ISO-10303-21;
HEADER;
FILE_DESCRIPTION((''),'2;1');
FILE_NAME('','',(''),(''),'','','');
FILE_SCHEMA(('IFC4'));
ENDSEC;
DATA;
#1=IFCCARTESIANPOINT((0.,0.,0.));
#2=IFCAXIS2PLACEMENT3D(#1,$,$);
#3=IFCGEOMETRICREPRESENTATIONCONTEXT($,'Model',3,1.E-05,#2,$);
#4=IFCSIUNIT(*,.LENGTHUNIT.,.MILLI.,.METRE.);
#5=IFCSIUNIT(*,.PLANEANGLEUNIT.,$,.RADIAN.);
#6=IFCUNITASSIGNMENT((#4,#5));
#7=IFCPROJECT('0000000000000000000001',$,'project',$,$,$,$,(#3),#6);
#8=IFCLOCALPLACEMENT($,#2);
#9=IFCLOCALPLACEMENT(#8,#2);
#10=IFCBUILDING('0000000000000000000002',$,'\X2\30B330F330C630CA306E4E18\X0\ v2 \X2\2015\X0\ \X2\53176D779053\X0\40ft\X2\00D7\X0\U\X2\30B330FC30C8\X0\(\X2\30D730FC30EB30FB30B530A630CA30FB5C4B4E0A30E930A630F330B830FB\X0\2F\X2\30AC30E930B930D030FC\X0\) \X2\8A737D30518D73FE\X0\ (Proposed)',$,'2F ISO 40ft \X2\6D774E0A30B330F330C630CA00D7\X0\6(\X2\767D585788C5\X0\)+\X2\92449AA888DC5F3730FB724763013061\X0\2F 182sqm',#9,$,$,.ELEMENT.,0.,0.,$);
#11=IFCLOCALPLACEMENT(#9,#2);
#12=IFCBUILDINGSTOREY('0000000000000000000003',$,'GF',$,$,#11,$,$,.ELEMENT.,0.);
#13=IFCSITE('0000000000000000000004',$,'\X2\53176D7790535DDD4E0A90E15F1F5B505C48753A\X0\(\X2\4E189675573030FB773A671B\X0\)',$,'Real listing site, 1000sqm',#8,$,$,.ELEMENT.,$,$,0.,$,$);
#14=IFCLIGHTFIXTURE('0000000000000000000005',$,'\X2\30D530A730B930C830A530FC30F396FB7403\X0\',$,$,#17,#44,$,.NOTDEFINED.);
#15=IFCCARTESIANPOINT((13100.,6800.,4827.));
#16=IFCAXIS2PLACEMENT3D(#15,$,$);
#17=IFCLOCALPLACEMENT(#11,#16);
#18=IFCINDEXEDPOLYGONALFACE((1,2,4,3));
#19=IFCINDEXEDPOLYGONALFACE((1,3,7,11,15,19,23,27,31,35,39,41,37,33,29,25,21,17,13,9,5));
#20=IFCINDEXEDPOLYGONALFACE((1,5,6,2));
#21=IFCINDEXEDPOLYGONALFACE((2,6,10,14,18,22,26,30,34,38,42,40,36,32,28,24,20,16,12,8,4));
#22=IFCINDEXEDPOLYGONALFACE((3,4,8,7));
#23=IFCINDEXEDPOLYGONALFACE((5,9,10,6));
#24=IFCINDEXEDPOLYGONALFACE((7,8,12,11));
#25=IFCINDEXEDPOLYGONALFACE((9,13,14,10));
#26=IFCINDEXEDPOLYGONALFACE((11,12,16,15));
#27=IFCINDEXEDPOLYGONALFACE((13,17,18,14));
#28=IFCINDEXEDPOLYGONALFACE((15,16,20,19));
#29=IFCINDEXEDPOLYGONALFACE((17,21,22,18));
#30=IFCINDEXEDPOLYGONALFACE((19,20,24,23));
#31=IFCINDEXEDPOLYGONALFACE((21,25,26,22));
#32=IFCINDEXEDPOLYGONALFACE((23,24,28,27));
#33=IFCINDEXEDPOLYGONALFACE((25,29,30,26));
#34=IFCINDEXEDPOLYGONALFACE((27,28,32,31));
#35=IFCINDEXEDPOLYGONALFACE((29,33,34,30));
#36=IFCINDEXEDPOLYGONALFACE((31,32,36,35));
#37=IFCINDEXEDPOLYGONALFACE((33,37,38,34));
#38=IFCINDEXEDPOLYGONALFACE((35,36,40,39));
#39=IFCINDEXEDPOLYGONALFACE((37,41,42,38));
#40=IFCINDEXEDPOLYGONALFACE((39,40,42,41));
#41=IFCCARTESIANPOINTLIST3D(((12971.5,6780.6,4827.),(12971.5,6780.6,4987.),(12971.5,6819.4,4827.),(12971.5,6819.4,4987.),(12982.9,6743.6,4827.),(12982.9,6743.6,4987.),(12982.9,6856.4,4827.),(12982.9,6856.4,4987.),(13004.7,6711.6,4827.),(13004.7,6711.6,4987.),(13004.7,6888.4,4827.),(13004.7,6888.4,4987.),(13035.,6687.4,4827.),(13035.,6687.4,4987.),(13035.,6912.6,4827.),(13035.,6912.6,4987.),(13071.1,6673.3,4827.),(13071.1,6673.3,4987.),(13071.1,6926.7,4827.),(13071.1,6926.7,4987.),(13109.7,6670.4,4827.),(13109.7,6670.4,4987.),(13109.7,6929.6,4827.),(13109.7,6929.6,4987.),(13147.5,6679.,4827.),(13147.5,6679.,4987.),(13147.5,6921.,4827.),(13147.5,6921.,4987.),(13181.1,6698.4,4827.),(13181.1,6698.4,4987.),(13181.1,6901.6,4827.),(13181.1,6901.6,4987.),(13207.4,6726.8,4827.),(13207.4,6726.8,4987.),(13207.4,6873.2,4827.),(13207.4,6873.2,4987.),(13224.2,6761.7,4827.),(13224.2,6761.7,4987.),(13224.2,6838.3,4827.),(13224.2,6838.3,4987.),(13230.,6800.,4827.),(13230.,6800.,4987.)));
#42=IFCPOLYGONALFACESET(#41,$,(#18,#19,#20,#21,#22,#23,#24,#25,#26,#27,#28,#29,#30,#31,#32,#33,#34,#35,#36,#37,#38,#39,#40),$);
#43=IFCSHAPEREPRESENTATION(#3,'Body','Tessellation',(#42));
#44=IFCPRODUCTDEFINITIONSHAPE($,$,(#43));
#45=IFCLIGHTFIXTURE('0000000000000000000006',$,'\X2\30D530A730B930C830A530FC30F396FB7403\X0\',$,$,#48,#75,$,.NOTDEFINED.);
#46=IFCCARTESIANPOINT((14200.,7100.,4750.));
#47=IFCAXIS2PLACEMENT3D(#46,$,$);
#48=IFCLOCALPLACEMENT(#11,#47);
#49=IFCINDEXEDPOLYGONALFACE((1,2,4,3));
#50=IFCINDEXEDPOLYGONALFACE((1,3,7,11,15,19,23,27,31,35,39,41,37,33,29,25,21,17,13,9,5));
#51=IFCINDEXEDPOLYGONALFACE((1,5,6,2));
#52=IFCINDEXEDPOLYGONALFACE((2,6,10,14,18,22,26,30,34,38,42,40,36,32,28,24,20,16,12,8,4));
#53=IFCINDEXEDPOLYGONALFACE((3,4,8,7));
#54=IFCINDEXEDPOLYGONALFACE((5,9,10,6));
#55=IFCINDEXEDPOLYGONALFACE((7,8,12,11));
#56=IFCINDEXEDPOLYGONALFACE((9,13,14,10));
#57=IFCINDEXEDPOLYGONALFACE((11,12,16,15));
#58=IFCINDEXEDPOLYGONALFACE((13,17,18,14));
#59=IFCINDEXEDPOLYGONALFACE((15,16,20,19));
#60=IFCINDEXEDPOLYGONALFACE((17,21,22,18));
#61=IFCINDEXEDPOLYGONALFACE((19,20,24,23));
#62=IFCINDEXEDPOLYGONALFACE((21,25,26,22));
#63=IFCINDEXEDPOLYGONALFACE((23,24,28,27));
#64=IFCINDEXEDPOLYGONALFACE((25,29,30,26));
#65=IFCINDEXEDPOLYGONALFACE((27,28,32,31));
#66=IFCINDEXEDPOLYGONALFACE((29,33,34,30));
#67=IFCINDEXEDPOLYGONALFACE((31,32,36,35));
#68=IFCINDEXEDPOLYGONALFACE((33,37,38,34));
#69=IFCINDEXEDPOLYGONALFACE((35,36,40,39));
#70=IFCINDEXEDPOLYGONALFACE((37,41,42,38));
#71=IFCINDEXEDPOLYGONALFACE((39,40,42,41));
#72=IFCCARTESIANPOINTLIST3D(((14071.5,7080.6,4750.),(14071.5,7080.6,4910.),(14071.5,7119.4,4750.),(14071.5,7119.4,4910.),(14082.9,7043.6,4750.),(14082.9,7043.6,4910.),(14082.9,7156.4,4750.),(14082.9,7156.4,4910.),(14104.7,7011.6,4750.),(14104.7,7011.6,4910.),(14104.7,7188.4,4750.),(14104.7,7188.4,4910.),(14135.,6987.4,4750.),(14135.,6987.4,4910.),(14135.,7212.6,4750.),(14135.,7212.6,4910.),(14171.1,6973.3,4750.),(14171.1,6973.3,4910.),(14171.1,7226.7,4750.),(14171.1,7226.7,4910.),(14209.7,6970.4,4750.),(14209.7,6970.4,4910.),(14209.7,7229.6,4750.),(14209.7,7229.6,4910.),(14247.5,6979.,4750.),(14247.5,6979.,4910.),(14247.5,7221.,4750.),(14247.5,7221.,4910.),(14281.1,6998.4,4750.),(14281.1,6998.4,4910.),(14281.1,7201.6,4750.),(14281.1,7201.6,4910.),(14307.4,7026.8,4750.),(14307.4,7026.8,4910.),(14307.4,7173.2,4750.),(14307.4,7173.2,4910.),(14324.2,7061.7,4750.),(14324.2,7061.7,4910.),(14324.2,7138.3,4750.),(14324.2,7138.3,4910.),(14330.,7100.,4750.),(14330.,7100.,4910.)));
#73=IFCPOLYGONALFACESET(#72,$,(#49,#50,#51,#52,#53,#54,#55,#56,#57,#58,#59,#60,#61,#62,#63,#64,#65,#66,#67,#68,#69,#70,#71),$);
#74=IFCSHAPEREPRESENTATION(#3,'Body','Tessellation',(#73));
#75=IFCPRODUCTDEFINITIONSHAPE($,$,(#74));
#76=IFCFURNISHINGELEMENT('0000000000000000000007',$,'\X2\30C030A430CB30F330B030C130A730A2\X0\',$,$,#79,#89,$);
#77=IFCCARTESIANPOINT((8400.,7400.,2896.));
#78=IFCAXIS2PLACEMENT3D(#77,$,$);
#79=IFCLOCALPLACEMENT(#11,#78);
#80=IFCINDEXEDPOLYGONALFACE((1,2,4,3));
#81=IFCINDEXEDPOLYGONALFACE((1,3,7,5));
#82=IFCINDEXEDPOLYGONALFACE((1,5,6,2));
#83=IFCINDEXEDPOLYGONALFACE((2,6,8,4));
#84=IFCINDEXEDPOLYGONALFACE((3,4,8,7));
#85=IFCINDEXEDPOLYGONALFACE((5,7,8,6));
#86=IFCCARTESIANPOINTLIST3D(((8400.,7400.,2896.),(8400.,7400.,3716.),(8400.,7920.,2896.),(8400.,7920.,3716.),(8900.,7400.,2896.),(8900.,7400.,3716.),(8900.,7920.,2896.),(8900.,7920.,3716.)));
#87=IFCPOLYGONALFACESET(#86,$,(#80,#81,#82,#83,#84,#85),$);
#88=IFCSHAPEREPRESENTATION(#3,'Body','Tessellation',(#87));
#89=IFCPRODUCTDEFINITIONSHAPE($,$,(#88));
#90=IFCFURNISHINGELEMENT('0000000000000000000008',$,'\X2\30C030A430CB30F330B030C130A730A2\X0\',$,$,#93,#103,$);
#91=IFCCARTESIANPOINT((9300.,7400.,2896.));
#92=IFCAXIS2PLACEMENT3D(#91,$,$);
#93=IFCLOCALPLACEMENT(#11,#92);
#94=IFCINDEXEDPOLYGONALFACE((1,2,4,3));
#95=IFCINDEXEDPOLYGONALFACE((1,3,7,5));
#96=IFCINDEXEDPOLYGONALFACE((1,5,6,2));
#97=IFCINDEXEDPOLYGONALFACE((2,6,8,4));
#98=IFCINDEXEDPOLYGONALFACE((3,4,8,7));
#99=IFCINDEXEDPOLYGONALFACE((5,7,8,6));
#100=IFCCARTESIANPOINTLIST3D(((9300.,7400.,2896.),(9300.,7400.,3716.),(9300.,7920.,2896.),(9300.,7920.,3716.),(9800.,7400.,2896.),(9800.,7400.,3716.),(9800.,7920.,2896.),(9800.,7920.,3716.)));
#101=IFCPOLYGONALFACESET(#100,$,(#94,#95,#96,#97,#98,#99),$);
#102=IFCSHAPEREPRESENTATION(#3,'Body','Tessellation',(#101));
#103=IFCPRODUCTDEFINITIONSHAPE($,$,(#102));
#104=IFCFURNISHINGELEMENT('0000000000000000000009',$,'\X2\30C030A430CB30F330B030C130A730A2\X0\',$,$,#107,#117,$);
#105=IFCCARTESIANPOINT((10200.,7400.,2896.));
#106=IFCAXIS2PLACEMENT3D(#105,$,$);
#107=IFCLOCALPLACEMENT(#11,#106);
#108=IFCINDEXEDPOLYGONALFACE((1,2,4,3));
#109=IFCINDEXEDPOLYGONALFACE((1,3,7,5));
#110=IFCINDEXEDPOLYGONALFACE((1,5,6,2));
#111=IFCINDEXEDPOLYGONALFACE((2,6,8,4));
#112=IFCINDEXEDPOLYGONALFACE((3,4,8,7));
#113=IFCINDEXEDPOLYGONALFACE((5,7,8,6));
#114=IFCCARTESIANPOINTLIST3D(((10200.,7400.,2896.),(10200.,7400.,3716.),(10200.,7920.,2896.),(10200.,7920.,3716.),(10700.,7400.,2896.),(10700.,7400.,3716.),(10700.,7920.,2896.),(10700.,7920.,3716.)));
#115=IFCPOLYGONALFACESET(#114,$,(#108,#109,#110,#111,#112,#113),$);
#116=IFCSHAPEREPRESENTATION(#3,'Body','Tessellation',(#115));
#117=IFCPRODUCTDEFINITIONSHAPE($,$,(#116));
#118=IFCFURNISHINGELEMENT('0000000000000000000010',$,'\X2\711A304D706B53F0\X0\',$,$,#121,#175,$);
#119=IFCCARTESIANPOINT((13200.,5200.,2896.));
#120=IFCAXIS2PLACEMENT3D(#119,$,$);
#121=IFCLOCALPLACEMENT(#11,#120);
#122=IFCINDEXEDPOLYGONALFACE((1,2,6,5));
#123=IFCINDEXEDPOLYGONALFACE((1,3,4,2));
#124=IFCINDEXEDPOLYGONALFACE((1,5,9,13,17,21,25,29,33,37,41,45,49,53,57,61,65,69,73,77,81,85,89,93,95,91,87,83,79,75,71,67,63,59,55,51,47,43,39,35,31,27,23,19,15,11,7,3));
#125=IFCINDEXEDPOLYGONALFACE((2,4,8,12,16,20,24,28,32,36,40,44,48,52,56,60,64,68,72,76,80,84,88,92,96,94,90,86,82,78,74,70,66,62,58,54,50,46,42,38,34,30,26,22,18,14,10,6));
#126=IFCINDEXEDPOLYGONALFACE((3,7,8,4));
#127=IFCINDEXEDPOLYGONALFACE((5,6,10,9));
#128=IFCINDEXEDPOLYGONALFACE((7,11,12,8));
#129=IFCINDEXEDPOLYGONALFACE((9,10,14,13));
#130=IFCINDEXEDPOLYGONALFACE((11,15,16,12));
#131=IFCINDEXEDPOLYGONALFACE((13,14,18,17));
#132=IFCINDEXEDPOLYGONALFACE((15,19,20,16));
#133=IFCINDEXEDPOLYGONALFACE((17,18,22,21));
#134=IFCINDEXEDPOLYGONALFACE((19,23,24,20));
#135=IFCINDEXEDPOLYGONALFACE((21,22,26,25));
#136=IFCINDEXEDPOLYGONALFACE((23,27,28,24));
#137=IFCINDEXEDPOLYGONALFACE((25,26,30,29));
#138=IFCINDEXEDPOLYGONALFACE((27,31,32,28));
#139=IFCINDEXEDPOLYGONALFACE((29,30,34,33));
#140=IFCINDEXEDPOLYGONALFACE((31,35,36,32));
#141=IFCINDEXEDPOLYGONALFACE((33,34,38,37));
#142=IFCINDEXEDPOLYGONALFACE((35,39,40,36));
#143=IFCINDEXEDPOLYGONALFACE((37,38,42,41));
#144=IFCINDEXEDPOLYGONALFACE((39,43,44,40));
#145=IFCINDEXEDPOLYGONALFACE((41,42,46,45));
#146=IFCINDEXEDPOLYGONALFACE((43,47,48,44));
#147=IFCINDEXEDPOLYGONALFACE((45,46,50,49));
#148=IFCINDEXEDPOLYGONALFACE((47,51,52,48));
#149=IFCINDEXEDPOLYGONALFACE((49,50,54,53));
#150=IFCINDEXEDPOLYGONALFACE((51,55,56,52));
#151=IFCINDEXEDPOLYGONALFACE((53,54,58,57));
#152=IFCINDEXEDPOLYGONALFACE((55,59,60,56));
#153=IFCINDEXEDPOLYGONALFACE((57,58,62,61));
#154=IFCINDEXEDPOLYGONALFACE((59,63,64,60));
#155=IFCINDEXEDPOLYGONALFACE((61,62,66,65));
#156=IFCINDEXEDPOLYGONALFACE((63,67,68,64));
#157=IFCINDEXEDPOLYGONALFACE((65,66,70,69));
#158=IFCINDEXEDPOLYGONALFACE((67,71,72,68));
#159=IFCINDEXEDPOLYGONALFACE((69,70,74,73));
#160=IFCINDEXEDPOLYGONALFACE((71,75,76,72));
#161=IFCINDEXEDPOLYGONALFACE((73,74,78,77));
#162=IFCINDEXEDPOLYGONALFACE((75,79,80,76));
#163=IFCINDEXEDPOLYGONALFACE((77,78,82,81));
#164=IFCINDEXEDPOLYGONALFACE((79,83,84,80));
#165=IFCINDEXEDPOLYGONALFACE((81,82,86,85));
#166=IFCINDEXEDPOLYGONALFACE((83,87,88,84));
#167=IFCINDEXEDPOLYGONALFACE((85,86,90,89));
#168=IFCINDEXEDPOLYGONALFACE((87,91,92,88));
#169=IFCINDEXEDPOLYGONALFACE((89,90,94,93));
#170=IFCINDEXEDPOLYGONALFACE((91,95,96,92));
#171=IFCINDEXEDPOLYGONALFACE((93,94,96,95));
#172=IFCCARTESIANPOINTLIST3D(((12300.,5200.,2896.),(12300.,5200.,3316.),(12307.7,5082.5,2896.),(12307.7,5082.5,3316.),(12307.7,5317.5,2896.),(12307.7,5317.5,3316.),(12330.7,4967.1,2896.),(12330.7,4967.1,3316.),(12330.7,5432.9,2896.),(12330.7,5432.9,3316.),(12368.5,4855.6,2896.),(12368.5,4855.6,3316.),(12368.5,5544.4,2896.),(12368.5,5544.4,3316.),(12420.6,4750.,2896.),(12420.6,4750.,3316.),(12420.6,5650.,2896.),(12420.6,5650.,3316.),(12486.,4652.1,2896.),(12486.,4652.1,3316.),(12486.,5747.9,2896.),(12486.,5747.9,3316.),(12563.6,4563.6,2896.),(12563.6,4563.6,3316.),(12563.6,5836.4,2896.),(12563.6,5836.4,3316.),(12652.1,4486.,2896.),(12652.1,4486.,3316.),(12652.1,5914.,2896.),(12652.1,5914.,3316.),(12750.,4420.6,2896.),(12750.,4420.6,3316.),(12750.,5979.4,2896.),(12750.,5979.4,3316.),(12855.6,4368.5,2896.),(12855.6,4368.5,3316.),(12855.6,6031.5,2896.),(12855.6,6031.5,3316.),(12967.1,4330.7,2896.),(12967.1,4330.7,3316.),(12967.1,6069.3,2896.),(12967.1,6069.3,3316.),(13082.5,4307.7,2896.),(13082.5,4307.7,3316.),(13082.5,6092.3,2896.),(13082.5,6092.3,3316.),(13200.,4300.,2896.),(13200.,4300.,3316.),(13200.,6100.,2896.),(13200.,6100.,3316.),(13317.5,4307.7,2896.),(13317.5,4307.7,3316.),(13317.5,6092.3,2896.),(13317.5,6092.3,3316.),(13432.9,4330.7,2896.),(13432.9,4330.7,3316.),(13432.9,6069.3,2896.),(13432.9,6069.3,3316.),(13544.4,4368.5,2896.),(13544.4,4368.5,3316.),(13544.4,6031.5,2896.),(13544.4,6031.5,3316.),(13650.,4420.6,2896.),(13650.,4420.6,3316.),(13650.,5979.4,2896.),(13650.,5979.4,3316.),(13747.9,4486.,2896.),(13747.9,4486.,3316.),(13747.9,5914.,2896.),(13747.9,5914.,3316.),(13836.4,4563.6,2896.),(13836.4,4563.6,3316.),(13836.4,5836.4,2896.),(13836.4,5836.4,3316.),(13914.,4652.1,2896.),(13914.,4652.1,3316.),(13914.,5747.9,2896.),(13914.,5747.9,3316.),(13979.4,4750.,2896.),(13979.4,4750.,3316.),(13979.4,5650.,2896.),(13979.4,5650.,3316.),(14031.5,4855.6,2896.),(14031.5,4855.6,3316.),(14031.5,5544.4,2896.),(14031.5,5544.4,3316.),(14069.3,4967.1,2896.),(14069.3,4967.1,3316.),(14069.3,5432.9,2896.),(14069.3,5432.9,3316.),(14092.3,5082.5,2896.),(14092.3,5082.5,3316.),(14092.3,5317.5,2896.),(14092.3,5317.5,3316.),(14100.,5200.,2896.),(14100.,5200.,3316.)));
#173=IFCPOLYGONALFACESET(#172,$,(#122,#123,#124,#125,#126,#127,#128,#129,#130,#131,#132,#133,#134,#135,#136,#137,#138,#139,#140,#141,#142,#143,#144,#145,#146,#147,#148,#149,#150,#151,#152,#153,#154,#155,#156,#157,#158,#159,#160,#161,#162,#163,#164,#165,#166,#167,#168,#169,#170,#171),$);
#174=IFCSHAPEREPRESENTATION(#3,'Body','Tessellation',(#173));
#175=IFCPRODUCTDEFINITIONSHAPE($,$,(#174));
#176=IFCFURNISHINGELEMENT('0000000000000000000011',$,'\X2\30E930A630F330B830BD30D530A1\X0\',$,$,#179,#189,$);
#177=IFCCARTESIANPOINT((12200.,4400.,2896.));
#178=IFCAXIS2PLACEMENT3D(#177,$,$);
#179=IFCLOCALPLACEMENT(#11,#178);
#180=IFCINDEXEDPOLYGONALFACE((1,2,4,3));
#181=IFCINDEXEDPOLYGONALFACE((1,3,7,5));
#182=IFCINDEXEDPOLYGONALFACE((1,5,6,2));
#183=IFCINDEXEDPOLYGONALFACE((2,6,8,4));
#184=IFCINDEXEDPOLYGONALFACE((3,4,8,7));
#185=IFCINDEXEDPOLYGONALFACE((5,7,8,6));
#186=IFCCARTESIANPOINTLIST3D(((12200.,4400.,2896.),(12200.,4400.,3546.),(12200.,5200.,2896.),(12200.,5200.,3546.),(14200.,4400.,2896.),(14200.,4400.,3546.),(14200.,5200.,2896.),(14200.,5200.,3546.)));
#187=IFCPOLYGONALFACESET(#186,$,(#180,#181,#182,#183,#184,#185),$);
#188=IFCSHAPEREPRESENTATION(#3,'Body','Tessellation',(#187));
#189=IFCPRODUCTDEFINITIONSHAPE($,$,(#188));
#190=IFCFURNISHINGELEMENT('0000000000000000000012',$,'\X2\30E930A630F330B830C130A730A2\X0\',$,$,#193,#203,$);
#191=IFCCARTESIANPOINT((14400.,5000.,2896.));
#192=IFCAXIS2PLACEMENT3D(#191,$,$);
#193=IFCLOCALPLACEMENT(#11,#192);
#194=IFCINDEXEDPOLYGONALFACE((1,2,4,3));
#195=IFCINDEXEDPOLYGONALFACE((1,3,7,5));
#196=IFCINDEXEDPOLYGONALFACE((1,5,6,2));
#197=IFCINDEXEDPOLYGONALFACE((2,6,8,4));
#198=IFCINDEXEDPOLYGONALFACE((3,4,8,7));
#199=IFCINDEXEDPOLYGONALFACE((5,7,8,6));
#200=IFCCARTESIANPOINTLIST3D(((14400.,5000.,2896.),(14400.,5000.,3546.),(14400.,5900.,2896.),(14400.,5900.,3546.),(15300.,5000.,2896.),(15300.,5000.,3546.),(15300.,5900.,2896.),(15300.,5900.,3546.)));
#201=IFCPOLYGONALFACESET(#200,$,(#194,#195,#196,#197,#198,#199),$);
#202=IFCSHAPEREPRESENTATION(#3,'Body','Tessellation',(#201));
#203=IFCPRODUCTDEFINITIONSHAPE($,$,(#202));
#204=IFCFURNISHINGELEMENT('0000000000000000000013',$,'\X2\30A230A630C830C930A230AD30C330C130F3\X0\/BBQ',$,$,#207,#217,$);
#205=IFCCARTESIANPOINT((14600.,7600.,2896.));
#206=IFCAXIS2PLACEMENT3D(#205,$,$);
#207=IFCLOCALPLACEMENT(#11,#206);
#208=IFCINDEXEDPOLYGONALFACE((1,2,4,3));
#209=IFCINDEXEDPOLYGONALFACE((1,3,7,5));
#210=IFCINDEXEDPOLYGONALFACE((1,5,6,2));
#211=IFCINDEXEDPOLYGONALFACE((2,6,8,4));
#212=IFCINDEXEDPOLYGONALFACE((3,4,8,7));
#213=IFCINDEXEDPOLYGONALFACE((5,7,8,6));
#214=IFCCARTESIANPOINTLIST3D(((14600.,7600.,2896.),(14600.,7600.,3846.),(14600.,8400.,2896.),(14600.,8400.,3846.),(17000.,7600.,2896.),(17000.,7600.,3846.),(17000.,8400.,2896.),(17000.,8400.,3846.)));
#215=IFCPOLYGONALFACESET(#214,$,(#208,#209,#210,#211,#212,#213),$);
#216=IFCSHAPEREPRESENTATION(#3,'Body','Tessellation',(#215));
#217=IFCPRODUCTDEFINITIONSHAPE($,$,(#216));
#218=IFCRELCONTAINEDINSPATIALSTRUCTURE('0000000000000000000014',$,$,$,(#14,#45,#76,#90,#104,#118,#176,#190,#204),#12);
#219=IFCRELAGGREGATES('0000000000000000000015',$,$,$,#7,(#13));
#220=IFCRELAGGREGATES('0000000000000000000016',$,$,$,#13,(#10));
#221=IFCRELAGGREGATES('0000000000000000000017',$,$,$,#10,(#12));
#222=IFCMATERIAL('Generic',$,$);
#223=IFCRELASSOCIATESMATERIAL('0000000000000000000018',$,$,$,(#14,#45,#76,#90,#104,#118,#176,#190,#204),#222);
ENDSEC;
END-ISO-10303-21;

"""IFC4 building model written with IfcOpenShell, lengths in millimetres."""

from ifc_helpers import new_model, si_unit, frame, frame_2d, origin, origin_2d, place, context, project, spatial, rectangle, circle, extrude, material, element, save


model = new_model("IFC4")

# Units and contexts
model_context = context("Model", 3, precision=1e-05, world=origin())
ifc_project = project(units=[si_unit("LENGTHUNIT", "METRE", prefix="MILLI"), si_unit("PLANEANGLEUNIT", "RADIAN")], contexts=[model_context])

# Site, building, storey
site_placement = place(None, origin())
site = spatial("IfcSite", under=ifc_project, at=site_placement, Name="北海道川上郡弟子屈町(丘陵地・眺望)", ObjectType="Real listing site, 1000sqm", CompositionType="ELEMENT", RefElevation=0.0)
building_placement = place(site_placement, origin())
building = spatial("IfcBuilding", under=site, at=building_placement, Name="コンテナの丘 v2 ― 北海道40ft×Uコート(プール・サウナ・屋上ラウンジ・2Fガラスバー) 詳細再現 (Proposed)", ObjectType="2F ISO 40ft 海上コンテナ×6(白塗装)+鉄骨補強・片持ち2F 182sqm", CompositionType="ELEMENT", ElevationOfRefHeight=0.0, ElevationOfTerrain=0.0)
storey_placement = place(building_placement, origin())
storey = spatial("IfcBuildingStorey", under=building, at=storey_placement, Name="GF", CompositionType="ELEMENT", Elevation=0.0)

# Shared definitions
ifc_material = material(Name="Generic")

# Light fixtures
light_fixture_1_placement = place(storey_placement, frame((13100.0, 6800.0, 4827.0)))
element("IfcLightFixture", 1, at=light_fixture_1_placement, inside=storey, material=ifc_material, Name="フェストゥーン電球", PredefinedType="NOTDEFINED", context=model_context, shape_type="SweptSolid", body=[
    extrude(circle(Radius=130.0, at=origin_2d()), frame((13100.0, 6800.0, 4827.0)), (0.0, 0.0, 1.0), 160.0),
])
light_fixture_2_placement = place(storey_placement, frame((14200.0, 7100.0, 4750.0)))
element("IfcLightFixture", 2, at=light_fixture_2_placement, inside=storey, material=ifc_material, Name="フェストゥーン電球", PredefinedType="NOTDEFINED", context=model_context, shape_type="SweptSolid", body=[
    extrude(circle(Radius=130.0, at=origin_2d()), frame((14200.0, 7100.0, 4750.0)), (0.0, 0.0, 1.0), 160.0),
])

# Furnishing elements
furnishing_1_placement = place(storey_placement, frame((8400.0, 7400.0, 2896.0)))
element("IfcFurnishingElement", 3, at=furnishing_1_placement, inside=storey, material=ifc_material, Name="ダイニングチェア", context=model_context, shape_type="SweptSolid", body=[
    extrude(rectangle(XDim=500.0, YDim=520.0, at=frame_2d((250.0, 260.0))), frame((8400.0, 7400.0, 2896.0)), (0.0, 0.0, 1.0), 820.0),
])
furnishing_2_placement = place(storey_placement, frame((9300.0, 7400.0, 2896.0)))
element("IfcFurnishingElement", 4, at=furnishing_2_placement, inside=storey, material=ifc_material, Name="ダイニングチェア", context=model_context, shape_type="SweptSolid", body=[
    extrude(rectangle(XDim=500.0, YDim=520.0, at=frame_2d((250.0, 260.0))), frame((9300.0, 7400.0, 2896.0)), (0.0, 0.0, 1.0), 820.0),
])
furnishing_3_placement = place(storey_placement, frame((10200.0, 7400.0, 2896.0)))
element("IfcFurnishingElement", 5, at=furnishing_3_placement, inside=storey, material=ifc_material, Name="ダイニングチェア", context=model_context, shape_type="SweptSolid", body=[
    extrude(rectangle(XDim=500.0, YDim=520.0, at=frame_2d((250.0, 260.0))), frame((10200.0, 7400.0, 2896.0)), (0.0, 0.0, 1.0), 820.0),
])
furnishing_4_placement = place(storey_placement, frame((13200.0, 5200.0, 2896.0)))
element("IfcFurnishingElement", 6, at=furnishing_4_placement, inside=storey, material=ifc_material, Name="焚き火台", context=model_context, shape_type="SweptSolid", body=[
    extrude(circle(Radius=900.0, at=origin_2d()), frame((13200.0, 5200.0, 2896.0)), (0.0, 0.0, 1.0), 420.0),
])
furnishing_5_placement = place(storey_placement, frame((12200.0, 4400.0, 2896.0)))
element("IfcFurnishingElement", 7, at=furnishing_5_placement, inside=storey, material=ifc_material, Name="ラウンジソファ", context=model_context, shape_type="SweptSolid", body=[
    extrude(rectangle(XDim=2000.0, YDim=800.0, at=frame_2d((1000.0, 400.0))), frame((12200.0, 4400.0, 2896.0)), (0.0, 0.0, 1.0), 650.0),
])
furnishing_6_placement = place(storey_placement, frame((14400.0, 5000.0, 2896.0)))
element("IfcFurnishingElement", 8, at=furnishing_6_placement, inside=storey, material=ifc_material, Name="ラウンジチェア", context=model_context, shape_type="SweptSolid", body=[
    extrude(rectangle(XDim=900.0, YDim=900.0, at=frame_2d((450.0, 450.0))), frame((14400.0, 5000.0, 2896.0)), (0.0, 0.0, 1.0), 650.0),
])
furnishing_7_placement = place(storey_placement, frame((14600.0, 7600.0, 2896.0)))
element("IfcFurnishingElement", 9, at=furnishing_7_placement, inside=storey, material=ifc_material, Name="アウトドアキッチン/BBQ", context=model_context, shape_type="SweptSolid", body=[
    extrude(rectangle(XDim=2400.0, YDim=800.0, at=frame_2d((1200.0, 400.0))), frame((14600.0, 7600.0, 2896.0)), (0.0, 0.0, 1.0), 950.0),
])

save(model, "model.ifc")
